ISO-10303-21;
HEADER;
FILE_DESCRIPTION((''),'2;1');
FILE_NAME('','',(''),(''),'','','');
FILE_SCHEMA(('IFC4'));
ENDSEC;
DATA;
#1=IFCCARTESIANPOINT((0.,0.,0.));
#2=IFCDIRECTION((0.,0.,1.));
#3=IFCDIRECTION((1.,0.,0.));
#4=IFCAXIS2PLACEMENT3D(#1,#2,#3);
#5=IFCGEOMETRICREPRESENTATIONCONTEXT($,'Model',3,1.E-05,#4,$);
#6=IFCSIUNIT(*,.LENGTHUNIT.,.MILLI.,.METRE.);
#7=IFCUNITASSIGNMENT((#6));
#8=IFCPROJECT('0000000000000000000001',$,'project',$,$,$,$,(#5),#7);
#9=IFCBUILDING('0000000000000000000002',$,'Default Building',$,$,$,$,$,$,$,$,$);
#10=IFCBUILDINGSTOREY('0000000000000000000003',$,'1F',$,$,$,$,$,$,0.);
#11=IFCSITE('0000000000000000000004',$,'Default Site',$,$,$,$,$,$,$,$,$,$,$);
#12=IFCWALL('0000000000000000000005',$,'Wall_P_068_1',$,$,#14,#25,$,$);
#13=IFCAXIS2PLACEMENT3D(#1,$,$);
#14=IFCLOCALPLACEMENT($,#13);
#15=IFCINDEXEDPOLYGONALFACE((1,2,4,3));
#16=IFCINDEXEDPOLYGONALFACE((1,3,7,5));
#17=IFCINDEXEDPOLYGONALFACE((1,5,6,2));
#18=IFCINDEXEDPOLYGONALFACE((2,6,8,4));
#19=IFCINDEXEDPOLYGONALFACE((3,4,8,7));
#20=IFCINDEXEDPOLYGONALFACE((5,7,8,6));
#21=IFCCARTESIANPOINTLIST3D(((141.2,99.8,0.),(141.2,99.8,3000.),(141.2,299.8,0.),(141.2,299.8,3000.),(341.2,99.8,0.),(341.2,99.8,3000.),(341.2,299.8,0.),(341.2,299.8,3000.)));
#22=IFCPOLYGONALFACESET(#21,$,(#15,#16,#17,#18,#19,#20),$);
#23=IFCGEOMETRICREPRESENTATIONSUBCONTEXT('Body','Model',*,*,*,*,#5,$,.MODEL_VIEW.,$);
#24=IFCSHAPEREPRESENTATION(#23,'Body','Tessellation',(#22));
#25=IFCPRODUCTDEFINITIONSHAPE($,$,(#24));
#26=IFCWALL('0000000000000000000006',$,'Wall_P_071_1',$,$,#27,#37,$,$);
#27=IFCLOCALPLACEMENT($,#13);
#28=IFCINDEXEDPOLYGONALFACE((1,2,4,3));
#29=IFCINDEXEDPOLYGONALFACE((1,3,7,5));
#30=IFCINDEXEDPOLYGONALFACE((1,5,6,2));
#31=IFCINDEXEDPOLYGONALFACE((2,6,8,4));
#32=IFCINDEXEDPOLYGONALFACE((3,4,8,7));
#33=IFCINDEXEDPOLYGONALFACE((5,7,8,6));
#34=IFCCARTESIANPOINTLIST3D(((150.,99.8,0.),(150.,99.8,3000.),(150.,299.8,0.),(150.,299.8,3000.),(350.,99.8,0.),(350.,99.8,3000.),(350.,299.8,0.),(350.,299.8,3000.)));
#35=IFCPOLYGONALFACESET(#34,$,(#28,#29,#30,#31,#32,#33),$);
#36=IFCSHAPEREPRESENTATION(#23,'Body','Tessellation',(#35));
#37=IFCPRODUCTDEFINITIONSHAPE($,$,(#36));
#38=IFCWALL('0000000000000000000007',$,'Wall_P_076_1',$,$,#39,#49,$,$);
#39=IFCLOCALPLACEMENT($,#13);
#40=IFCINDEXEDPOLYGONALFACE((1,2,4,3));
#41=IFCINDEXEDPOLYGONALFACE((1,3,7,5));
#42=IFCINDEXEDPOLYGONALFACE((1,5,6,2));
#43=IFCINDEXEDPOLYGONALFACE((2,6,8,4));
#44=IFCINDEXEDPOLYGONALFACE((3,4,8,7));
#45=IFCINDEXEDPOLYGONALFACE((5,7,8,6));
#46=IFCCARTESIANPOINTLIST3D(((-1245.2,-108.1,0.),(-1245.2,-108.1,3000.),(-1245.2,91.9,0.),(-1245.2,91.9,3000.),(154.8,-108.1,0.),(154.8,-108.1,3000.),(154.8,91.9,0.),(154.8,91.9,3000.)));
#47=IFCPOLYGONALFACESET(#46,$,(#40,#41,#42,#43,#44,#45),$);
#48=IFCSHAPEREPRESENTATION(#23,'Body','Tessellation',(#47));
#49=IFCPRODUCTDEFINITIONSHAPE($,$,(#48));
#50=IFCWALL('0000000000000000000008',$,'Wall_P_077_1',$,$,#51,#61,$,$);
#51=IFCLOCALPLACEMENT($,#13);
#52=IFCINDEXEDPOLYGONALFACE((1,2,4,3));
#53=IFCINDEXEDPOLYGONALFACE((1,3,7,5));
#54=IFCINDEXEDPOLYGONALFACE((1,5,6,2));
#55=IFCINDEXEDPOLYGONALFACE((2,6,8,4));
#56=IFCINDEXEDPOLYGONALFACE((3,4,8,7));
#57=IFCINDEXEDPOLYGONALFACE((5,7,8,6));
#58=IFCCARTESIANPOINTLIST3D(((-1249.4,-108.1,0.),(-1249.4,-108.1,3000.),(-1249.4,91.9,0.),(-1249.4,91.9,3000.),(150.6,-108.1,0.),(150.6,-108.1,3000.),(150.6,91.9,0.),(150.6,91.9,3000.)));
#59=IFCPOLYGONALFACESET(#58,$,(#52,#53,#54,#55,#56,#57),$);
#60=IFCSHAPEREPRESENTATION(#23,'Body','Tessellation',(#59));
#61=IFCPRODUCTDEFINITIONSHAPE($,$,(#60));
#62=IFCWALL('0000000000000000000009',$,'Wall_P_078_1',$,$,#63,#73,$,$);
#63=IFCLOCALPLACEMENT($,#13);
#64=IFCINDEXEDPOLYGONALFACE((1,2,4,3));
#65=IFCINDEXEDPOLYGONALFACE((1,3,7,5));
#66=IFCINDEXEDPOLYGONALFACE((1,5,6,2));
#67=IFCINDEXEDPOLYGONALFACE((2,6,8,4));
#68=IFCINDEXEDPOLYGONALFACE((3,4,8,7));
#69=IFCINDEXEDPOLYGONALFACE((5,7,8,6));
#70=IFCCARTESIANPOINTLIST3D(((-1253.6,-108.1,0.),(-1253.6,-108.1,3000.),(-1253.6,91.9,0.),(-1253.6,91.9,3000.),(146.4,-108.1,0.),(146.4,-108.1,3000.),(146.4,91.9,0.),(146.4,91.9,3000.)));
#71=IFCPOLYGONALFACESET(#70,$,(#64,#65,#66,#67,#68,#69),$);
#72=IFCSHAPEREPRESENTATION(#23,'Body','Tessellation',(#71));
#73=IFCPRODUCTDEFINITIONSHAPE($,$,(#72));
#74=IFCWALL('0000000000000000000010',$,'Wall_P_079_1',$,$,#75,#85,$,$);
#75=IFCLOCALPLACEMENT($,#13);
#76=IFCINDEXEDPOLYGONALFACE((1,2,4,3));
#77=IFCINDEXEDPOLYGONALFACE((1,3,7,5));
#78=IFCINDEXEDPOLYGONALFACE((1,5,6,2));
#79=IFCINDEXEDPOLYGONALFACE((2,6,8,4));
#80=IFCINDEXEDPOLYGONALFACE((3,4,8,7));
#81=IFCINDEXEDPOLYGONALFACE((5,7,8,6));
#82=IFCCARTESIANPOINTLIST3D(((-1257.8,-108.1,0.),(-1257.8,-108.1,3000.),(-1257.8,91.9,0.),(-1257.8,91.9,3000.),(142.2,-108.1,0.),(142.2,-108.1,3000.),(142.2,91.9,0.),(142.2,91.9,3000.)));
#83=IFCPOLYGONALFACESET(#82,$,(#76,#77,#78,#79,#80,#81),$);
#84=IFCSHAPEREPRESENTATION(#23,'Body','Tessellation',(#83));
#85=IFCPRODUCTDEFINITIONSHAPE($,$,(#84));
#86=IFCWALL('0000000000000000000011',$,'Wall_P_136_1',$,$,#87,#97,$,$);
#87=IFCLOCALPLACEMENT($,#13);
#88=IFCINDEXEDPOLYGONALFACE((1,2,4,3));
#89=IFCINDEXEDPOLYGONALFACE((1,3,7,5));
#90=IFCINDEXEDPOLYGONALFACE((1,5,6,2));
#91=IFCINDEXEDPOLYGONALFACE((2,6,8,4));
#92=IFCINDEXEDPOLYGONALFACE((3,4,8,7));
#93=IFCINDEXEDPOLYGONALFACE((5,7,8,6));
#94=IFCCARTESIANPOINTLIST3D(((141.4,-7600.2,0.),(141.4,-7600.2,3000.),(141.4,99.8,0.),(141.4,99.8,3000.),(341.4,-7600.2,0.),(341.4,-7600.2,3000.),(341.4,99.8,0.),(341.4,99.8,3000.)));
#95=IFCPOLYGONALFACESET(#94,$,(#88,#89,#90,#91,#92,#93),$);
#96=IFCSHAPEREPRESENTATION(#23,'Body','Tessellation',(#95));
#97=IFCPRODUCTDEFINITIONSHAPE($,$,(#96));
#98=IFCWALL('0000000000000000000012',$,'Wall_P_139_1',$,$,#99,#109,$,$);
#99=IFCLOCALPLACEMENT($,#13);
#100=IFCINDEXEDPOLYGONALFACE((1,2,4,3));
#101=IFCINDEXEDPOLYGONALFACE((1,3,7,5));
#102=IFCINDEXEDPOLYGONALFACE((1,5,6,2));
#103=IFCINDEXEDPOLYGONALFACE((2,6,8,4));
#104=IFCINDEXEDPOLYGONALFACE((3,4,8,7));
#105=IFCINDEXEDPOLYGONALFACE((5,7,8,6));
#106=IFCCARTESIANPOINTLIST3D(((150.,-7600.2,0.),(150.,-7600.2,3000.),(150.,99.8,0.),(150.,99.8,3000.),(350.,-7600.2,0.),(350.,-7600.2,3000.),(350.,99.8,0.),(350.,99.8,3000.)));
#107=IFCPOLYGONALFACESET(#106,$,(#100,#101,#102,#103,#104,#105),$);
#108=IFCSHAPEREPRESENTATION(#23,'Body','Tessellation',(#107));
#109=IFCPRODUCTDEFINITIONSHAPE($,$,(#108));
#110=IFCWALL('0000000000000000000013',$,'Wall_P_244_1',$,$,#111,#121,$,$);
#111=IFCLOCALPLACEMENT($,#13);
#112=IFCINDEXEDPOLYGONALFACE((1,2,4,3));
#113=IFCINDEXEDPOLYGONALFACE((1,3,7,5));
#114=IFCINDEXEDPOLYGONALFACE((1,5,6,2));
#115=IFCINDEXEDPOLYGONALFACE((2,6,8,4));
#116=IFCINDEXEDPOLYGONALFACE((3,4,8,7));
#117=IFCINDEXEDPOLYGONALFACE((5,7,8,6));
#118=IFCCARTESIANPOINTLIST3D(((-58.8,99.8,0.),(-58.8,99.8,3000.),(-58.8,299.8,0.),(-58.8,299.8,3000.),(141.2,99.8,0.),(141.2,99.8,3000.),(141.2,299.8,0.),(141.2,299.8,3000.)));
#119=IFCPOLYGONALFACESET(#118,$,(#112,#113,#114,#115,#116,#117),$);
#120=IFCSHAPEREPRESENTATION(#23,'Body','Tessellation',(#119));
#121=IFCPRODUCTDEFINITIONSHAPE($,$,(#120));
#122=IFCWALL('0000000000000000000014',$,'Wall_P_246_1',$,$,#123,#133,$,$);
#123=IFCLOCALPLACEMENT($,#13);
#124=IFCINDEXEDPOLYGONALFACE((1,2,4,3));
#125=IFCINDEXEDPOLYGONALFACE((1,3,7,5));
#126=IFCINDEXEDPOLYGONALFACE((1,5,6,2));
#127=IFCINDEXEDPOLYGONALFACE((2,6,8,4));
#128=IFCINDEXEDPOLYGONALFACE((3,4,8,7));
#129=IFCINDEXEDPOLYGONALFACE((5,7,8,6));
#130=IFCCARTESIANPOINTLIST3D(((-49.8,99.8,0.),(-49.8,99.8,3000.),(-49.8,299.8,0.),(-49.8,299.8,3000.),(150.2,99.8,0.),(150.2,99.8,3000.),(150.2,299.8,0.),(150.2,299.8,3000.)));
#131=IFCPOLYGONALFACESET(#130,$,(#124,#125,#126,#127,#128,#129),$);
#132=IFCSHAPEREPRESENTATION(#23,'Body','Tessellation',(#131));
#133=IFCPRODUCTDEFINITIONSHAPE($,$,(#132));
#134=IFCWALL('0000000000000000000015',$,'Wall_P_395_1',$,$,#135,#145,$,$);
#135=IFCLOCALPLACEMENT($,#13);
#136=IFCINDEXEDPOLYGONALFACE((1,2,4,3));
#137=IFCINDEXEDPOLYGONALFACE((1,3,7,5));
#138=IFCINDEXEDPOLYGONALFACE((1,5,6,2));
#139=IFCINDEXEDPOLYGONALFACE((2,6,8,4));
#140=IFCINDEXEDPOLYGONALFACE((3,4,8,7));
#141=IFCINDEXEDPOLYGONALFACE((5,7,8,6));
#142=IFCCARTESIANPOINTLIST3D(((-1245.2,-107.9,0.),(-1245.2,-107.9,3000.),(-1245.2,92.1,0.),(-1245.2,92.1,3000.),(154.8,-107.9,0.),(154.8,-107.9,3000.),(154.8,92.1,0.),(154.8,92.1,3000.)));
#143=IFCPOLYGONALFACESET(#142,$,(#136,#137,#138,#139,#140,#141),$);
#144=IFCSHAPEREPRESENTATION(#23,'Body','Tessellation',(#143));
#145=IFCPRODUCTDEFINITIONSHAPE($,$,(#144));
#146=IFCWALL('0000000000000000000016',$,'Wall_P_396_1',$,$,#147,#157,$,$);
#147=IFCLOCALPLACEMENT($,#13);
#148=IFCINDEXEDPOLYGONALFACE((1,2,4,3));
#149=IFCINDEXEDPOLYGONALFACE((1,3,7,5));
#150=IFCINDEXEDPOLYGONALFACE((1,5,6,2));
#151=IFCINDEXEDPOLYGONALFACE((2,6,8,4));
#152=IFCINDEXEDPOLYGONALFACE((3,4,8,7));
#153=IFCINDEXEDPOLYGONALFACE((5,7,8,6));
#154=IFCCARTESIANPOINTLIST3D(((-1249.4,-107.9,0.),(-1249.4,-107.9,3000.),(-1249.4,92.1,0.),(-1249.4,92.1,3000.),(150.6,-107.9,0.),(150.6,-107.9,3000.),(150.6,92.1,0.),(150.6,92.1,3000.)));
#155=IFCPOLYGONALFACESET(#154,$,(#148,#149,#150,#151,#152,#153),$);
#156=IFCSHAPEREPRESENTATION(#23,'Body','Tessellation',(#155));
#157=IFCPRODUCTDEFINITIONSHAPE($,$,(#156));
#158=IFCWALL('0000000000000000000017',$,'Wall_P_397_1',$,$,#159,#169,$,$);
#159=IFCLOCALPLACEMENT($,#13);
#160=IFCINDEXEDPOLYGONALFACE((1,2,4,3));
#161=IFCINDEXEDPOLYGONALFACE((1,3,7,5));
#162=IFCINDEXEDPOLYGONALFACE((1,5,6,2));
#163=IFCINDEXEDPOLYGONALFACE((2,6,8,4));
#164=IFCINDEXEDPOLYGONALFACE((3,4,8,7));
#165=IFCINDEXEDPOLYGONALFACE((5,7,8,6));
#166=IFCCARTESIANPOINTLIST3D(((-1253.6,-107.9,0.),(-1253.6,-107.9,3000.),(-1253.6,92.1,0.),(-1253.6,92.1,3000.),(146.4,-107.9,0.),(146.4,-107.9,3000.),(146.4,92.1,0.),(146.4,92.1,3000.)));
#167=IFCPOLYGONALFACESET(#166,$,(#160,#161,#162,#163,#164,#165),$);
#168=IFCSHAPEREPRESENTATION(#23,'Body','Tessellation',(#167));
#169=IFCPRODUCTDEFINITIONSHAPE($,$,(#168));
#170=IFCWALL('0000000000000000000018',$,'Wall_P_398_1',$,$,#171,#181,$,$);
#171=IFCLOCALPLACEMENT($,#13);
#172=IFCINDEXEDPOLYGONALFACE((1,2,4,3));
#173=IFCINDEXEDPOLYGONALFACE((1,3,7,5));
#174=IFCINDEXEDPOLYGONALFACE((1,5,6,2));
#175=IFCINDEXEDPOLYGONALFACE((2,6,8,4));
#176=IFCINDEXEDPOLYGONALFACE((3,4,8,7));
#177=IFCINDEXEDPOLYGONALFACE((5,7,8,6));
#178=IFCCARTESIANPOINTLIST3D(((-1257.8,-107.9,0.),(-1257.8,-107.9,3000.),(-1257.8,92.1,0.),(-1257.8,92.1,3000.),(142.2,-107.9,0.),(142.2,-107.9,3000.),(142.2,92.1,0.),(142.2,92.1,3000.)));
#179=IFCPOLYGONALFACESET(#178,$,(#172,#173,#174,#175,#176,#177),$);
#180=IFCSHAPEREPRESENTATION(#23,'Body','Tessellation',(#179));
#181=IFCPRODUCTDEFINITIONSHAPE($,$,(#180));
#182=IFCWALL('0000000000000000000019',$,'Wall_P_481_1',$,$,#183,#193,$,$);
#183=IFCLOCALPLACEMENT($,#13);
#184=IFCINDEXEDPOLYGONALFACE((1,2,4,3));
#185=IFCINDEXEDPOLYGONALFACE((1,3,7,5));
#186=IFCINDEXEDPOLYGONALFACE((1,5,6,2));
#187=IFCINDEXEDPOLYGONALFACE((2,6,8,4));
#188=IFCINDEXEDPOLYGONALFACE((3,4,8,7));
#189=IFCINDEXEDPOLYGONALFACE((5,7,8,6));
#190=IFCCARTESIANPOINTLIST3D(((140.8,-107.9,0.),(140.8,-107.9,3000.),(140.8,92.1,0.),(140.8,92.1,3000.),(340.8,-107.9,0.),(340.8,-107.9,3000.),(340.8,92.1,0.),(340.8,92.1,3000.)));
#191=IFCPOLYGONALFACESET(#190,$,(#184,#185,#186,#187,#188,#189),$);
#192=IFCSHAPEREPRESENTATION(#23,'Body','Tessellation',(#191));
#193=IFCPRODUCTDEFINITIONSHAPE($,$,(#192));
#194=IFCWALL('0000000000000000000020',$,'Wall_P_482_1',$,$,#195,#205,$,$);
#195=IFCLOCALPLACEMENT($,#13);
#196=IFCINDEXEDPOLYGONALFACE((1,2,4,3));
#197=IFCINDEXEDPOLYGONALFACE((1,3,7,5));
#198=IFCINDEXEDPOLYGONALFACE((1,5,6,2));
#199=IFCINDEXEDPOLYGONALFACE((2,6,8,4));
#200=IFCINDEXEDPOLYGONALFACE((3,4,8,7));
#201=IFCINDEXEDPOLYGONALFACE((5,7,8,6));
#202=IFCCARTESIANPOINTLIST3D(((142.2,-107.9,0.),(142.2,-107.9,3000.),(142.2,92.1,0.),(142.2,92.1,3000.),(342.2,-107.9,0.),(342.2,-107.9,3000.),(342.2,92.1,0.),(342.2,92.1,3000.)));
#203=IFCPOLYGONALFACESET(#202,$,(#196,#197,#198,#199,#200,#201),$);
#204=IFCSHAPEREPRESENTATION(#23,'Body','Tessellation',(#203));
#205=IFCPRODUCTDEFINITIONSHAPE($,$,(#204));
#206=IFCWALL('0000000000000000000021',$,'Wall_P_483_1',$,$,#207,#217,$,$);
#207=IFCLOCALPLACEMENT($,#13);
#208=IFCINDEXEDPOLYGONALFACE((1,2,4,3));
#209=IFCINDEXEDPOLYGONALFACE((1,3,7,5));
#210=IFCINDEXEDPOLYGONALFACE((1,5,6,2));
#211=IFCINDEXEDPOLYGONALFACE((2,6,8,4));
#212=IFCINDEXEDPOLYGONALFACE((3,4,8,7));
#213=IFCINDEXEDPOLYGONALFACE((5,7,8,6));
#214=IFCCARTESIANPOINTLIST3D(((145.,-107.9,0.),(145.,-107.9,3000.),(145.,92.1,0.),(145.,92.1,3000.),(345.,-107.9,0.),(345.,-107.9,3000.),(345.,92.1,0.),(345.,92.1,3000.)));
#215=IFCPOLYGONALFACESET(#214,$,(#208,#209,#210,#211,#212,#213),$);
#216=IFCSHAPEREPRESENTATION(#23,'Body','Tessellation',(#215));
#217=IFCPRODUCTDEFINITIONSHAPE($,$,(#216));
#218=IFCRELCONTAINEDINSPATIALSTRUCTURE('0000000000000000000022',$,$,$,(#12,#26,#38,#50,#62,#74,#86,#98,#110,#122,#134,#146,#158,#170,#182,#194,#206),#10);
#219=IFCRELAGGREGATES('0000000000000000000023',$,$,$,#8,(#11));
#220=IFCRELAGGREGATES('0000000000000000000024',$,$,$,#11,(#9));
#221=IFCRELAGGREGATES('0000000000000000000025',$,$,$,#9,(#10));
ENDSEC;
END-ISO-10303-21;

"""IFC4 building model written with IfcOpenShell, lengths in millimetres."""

from ifc_helpers import new_model, si_unit, frame, origin_with_axes, place, context, subcontext, project, spatial, indexed_curve, outline, extrude, element, save


model = new_model("IFC4")

# Units and contexts
model_context = context("Model", 3, precision=1e-05, world=origin_with_axes())
body_context = subcontext(model_context, "Body", "Model", "MODEL_VIEW")
ifc_project = project(units=[si_unit("LENGTHUNIT", "METRE", prefix="MILLI")], contexts=[model_context])

# Site, building, storey
site = spatial("IfcSite", under=ifc_project, Name="Default Site")
building = spatial("IfcBuilding", under=site, Name="Default Building")
storey = spatial("IfcBuildingStorey", under=building, Name="1F", Elevation=0.0)

# Walls
wall_1_placement = place(None, frame((141.2, 99.8, 0.0), z_axis=(0.0, 0.0, 1.0), x_axis=(1.0, 0.0, 0.0)))
element("IfcWall", 1, at=wall_1_placement, inside=storey, Name="Wall_P_068_1", context=body_context, shape_type="SweptSolid", body=[
    extrude(outline(indexed_curve([(0.0, 0.0), (0.0, 200.0), (200.0, 200.0), (200.0, 0.0), (0.0, 0.0)], self_intersect=False)), origin_with_axes(), (0.0, 0.0, 1.0), 3000.0),
])
wall_2_placement = place(None, frame((150.0, 99.8, 0.0), z_axis=(0.0, 0.0, 1.0), x_axis=(1.0, 0.0, 0.0)))
element("IfcWall", 2, at=wall_2_placement, inside=storey, Name="Wall_P_071_1", context=body_context, shape_type="SweptSolid", body=[
    extrude(outline(indexed_curve([(0.0, 0.0), (0.0, 200.0), (200.0, 200.0), (200.0, 0.0), (0.0, 0.0)], self_intersect=False)), origin_with_axes(), (0.0, 0.0, 1.0), 3000.0),
])
for number, where, z_axis, x_axis, name in (
    (3, (154.8, 91.9, 0.0), (0.0, 0.0, 1.0), (-1.0, 0.0, 0.0), "Wall_P_076_1"),
    (4, (150.6, 91.9, 0.0), (0.0, 0.0, 1.0), (-1.0, 0.0, 0.0), "Wall_P_077_1"),
):
    element("IfcWall", number, at=place(None, frame(where, z_axis=z_axis, x_axis=x_axis)), inside=storey, Name=name, context=body_context, shape_type="SweptSolid", body=[
        extrude(outline(indexed_curve([(0.0, 0.0), (0.0, 200.0), (1400.0, 200.0), (1400.0, 0.0), (0.0, 0.0)], self_intersect=False)), origin_with_axes(), (0.0, 0.0, 1.0), 3000.0),
    ])
wall_3_placement = place(None, frame((146.4, 91.9, 0.0), z_axis=(0.0, 0.0, 1.0), x_axis=(-1.0, 0.0, 0.0)))
element("IfcWall", 5, at=wall_3_placement, inside=storey, Name="Wall_P_078_1", context=body_context, shape_type="SweptSolid", body=[
    extrude(outline(indexed_curve([(0.0, 0.0), (0.0, 200.0), (1400.0, 200.0), (1400.0, 0.0), (0.0, 0.0)], self_intersect=False)), origin_with_axes(), (0.0, 0.0, 1.0), 3000.0),
])
wall_4_placement = place(None, frame((142.2, 91.9, 0.0), z_axis=(0.0, 0.0, 1.0), x_axis=(-1.0, 0.0, 0.0)))
element("IfcWall", 6, at=wall_4_placement, inside=storey, Name="Wall_P_079_1", context=body_context, shape_type="SweptSolid", body=[
    extrude(outline(indexed_curve([(0.0, 0.0), (0.0, 200.0), (1400.0, 200.0), (1400.0, 0.0), (0.0, 0.0)], self_intersect=False)), origin_with_axes(), (0.0, 0.0, 1.0), 3000.0),
])
for number, where, z_axis, x_axis, name in (
    (7, (141.4, 99.8, 0.0), (0.0, 0.0, 1.0), (0.0, -1.0, 0.0), "Wall_P_136_1"),
    (8, (150.0, 99.8, 0.0), (0.0, 0.0, 1.0), (0.0, -1.0, 0.0), "Wall_P_139_1"),
):
    element("IfcWall", number, at=place(None, frame(where, z_axis=z_axis, x_axis=x_axis)), inside=storey, Name=name, context=body_context, shape_type="SweptSolid", body=[
        extrude(outline(indexed_curve([(0.0, 0.0), (0.0, 200.0), (7700.0, 200.0), (7700.0, 0.0), (0.0, 0.0)], self_intersect=False)), origin_with_axes(), (0.0, 0.0, 1.0), 3000.0),
    ])
for number, where, z_axis, x_axis, name in (
    (9, (141.2, 99.8, 0.0), (0.0, 0.0, 1.0), (0.0, 1.0, 0.0), "Wall_P_244_1"),
    (10, (150.2, 99.8, 0.0), (0.0, 0.0, 1.0), (0.0, 1.0, 0.0), "Wall_P_246_1"),
):
    element("IfcWall", number, at=place(None, frame(where, z_axis=z_axis, x_axis=x_axis)), inside=storey, Name=name, context=body_context, shape_type="SweptSolid", body=[
        extrude(outline(indexed_curve([(0.0, 0.0), (0.0, 200.0), (200.0, 200.0), (200.0, 0.0), (0.0, 0.0)], self_intersect=False)), origin_with_axes(), (0.0, 0.0, 1.0), 3000.0),
    ])
for number, where, z_axis, x_axis, name in (
    (11, (154.8, 92.1, 0.0), (0.0, 0.0, 1.0), (-1.0, 0.0, 0.0), "Wall_P_395_1"),
    (12, (150.6, 92.1, 0.0), (0.0, 0.0, 1.0), (-1.0, 0.0, 0.0), "Wall_P_396_1"),
):
    element("IfcWall", number, at=place(None, frame(where, z_axis=z_axis, x_axis=x_axis)), inside=storey, Name=name, context=body_context, shape_type="SweptSolid", body=[
        extrude(outline(indexed_curve([(0.0, 0.0), (0.0, 200.0), (1400.0, 200.0), (1400.0, 0.0), (0.0, 0.0)], self_intersect=False)), origin_with_axes(), (0.0, 0.0, 1.0), 3000.0),
    ])
wall_5_placement = place(None, frame((146.4, 92.1, 0.0), z_axis=(0.0, 0.0, 1.0), x_axis=(-1.0, 0.0, 0.0)))
element("IfcWall", 13, at=wall_5_placement, inside=storey, Name="Wall_P_397_1", context=body_context, shape_type="SweptSolid", body=[
    extrude(outline(indexed_curve([(0.0, 0.0), (0.0, 200.0), (1400.0, 200.0), (1400.0, 0.0), (0.0, 0.0)], self_intersect=False)), origin_with_axes(), (0.0, 0.0, 1.0), 3000.0),
])
wall_6_placement = place(None, frame((142.2, 92.1, 0.0), z_axis=(0.0, 0.0, 1.0), x_axis=(-1.0, 0.0, 0.0)))
element("IfcWall", 14, at=wall_6_placement, inside=storey, Name="Wall_P_398_1", context=body_context, shape_type="SweptSolid", body=[
    extrude(outline(indexed_curve([(0.0, 0.0), (0.0, 200.0), (1400.0, 200.0), (1400.0, 0.0), (0.0, 0.0)], self_intersect=False)), origin_with_axes(), (0.0, 0.0, 1.0), 3000.0),
])
for number, where, z_axis, x_axis, name in (
    (15, (140.8, 92.1, 0.0), (0.0, 0.0, 1.0), (0.0, -1.0, 0.0), "Wall_P_481_1"),
    (16, (142.2, 92.1, 0.0), (0.0, 0.0, 1.0), (0.0, -1.0, 0.0), "Wall_P_482_1"),
    (17, (145.0, 92.1, 0.0), (0.0, 0.0, 1.0), (0.0, -1.0, 0.0), "Wall_P_483_1"),
):
    element("IfcWall", number, at=place(None, frame(where, z_axis=z_axis, x_axis=x_axis)), inside=storey, Name=name, context=body_context, shape_type="SweptSolid", body=[
        extrude(outline(indexed_curve([(0.0, 0.0), (0.0, 200.0), (200.0, 200.0), (200.0, 0.0), (0.0, 0.0)], self_intersect=False)), origin_with_axes(), (0.0, 0.0, 1.0), 3000.0),
    ])

save(model, "model.ifc")
